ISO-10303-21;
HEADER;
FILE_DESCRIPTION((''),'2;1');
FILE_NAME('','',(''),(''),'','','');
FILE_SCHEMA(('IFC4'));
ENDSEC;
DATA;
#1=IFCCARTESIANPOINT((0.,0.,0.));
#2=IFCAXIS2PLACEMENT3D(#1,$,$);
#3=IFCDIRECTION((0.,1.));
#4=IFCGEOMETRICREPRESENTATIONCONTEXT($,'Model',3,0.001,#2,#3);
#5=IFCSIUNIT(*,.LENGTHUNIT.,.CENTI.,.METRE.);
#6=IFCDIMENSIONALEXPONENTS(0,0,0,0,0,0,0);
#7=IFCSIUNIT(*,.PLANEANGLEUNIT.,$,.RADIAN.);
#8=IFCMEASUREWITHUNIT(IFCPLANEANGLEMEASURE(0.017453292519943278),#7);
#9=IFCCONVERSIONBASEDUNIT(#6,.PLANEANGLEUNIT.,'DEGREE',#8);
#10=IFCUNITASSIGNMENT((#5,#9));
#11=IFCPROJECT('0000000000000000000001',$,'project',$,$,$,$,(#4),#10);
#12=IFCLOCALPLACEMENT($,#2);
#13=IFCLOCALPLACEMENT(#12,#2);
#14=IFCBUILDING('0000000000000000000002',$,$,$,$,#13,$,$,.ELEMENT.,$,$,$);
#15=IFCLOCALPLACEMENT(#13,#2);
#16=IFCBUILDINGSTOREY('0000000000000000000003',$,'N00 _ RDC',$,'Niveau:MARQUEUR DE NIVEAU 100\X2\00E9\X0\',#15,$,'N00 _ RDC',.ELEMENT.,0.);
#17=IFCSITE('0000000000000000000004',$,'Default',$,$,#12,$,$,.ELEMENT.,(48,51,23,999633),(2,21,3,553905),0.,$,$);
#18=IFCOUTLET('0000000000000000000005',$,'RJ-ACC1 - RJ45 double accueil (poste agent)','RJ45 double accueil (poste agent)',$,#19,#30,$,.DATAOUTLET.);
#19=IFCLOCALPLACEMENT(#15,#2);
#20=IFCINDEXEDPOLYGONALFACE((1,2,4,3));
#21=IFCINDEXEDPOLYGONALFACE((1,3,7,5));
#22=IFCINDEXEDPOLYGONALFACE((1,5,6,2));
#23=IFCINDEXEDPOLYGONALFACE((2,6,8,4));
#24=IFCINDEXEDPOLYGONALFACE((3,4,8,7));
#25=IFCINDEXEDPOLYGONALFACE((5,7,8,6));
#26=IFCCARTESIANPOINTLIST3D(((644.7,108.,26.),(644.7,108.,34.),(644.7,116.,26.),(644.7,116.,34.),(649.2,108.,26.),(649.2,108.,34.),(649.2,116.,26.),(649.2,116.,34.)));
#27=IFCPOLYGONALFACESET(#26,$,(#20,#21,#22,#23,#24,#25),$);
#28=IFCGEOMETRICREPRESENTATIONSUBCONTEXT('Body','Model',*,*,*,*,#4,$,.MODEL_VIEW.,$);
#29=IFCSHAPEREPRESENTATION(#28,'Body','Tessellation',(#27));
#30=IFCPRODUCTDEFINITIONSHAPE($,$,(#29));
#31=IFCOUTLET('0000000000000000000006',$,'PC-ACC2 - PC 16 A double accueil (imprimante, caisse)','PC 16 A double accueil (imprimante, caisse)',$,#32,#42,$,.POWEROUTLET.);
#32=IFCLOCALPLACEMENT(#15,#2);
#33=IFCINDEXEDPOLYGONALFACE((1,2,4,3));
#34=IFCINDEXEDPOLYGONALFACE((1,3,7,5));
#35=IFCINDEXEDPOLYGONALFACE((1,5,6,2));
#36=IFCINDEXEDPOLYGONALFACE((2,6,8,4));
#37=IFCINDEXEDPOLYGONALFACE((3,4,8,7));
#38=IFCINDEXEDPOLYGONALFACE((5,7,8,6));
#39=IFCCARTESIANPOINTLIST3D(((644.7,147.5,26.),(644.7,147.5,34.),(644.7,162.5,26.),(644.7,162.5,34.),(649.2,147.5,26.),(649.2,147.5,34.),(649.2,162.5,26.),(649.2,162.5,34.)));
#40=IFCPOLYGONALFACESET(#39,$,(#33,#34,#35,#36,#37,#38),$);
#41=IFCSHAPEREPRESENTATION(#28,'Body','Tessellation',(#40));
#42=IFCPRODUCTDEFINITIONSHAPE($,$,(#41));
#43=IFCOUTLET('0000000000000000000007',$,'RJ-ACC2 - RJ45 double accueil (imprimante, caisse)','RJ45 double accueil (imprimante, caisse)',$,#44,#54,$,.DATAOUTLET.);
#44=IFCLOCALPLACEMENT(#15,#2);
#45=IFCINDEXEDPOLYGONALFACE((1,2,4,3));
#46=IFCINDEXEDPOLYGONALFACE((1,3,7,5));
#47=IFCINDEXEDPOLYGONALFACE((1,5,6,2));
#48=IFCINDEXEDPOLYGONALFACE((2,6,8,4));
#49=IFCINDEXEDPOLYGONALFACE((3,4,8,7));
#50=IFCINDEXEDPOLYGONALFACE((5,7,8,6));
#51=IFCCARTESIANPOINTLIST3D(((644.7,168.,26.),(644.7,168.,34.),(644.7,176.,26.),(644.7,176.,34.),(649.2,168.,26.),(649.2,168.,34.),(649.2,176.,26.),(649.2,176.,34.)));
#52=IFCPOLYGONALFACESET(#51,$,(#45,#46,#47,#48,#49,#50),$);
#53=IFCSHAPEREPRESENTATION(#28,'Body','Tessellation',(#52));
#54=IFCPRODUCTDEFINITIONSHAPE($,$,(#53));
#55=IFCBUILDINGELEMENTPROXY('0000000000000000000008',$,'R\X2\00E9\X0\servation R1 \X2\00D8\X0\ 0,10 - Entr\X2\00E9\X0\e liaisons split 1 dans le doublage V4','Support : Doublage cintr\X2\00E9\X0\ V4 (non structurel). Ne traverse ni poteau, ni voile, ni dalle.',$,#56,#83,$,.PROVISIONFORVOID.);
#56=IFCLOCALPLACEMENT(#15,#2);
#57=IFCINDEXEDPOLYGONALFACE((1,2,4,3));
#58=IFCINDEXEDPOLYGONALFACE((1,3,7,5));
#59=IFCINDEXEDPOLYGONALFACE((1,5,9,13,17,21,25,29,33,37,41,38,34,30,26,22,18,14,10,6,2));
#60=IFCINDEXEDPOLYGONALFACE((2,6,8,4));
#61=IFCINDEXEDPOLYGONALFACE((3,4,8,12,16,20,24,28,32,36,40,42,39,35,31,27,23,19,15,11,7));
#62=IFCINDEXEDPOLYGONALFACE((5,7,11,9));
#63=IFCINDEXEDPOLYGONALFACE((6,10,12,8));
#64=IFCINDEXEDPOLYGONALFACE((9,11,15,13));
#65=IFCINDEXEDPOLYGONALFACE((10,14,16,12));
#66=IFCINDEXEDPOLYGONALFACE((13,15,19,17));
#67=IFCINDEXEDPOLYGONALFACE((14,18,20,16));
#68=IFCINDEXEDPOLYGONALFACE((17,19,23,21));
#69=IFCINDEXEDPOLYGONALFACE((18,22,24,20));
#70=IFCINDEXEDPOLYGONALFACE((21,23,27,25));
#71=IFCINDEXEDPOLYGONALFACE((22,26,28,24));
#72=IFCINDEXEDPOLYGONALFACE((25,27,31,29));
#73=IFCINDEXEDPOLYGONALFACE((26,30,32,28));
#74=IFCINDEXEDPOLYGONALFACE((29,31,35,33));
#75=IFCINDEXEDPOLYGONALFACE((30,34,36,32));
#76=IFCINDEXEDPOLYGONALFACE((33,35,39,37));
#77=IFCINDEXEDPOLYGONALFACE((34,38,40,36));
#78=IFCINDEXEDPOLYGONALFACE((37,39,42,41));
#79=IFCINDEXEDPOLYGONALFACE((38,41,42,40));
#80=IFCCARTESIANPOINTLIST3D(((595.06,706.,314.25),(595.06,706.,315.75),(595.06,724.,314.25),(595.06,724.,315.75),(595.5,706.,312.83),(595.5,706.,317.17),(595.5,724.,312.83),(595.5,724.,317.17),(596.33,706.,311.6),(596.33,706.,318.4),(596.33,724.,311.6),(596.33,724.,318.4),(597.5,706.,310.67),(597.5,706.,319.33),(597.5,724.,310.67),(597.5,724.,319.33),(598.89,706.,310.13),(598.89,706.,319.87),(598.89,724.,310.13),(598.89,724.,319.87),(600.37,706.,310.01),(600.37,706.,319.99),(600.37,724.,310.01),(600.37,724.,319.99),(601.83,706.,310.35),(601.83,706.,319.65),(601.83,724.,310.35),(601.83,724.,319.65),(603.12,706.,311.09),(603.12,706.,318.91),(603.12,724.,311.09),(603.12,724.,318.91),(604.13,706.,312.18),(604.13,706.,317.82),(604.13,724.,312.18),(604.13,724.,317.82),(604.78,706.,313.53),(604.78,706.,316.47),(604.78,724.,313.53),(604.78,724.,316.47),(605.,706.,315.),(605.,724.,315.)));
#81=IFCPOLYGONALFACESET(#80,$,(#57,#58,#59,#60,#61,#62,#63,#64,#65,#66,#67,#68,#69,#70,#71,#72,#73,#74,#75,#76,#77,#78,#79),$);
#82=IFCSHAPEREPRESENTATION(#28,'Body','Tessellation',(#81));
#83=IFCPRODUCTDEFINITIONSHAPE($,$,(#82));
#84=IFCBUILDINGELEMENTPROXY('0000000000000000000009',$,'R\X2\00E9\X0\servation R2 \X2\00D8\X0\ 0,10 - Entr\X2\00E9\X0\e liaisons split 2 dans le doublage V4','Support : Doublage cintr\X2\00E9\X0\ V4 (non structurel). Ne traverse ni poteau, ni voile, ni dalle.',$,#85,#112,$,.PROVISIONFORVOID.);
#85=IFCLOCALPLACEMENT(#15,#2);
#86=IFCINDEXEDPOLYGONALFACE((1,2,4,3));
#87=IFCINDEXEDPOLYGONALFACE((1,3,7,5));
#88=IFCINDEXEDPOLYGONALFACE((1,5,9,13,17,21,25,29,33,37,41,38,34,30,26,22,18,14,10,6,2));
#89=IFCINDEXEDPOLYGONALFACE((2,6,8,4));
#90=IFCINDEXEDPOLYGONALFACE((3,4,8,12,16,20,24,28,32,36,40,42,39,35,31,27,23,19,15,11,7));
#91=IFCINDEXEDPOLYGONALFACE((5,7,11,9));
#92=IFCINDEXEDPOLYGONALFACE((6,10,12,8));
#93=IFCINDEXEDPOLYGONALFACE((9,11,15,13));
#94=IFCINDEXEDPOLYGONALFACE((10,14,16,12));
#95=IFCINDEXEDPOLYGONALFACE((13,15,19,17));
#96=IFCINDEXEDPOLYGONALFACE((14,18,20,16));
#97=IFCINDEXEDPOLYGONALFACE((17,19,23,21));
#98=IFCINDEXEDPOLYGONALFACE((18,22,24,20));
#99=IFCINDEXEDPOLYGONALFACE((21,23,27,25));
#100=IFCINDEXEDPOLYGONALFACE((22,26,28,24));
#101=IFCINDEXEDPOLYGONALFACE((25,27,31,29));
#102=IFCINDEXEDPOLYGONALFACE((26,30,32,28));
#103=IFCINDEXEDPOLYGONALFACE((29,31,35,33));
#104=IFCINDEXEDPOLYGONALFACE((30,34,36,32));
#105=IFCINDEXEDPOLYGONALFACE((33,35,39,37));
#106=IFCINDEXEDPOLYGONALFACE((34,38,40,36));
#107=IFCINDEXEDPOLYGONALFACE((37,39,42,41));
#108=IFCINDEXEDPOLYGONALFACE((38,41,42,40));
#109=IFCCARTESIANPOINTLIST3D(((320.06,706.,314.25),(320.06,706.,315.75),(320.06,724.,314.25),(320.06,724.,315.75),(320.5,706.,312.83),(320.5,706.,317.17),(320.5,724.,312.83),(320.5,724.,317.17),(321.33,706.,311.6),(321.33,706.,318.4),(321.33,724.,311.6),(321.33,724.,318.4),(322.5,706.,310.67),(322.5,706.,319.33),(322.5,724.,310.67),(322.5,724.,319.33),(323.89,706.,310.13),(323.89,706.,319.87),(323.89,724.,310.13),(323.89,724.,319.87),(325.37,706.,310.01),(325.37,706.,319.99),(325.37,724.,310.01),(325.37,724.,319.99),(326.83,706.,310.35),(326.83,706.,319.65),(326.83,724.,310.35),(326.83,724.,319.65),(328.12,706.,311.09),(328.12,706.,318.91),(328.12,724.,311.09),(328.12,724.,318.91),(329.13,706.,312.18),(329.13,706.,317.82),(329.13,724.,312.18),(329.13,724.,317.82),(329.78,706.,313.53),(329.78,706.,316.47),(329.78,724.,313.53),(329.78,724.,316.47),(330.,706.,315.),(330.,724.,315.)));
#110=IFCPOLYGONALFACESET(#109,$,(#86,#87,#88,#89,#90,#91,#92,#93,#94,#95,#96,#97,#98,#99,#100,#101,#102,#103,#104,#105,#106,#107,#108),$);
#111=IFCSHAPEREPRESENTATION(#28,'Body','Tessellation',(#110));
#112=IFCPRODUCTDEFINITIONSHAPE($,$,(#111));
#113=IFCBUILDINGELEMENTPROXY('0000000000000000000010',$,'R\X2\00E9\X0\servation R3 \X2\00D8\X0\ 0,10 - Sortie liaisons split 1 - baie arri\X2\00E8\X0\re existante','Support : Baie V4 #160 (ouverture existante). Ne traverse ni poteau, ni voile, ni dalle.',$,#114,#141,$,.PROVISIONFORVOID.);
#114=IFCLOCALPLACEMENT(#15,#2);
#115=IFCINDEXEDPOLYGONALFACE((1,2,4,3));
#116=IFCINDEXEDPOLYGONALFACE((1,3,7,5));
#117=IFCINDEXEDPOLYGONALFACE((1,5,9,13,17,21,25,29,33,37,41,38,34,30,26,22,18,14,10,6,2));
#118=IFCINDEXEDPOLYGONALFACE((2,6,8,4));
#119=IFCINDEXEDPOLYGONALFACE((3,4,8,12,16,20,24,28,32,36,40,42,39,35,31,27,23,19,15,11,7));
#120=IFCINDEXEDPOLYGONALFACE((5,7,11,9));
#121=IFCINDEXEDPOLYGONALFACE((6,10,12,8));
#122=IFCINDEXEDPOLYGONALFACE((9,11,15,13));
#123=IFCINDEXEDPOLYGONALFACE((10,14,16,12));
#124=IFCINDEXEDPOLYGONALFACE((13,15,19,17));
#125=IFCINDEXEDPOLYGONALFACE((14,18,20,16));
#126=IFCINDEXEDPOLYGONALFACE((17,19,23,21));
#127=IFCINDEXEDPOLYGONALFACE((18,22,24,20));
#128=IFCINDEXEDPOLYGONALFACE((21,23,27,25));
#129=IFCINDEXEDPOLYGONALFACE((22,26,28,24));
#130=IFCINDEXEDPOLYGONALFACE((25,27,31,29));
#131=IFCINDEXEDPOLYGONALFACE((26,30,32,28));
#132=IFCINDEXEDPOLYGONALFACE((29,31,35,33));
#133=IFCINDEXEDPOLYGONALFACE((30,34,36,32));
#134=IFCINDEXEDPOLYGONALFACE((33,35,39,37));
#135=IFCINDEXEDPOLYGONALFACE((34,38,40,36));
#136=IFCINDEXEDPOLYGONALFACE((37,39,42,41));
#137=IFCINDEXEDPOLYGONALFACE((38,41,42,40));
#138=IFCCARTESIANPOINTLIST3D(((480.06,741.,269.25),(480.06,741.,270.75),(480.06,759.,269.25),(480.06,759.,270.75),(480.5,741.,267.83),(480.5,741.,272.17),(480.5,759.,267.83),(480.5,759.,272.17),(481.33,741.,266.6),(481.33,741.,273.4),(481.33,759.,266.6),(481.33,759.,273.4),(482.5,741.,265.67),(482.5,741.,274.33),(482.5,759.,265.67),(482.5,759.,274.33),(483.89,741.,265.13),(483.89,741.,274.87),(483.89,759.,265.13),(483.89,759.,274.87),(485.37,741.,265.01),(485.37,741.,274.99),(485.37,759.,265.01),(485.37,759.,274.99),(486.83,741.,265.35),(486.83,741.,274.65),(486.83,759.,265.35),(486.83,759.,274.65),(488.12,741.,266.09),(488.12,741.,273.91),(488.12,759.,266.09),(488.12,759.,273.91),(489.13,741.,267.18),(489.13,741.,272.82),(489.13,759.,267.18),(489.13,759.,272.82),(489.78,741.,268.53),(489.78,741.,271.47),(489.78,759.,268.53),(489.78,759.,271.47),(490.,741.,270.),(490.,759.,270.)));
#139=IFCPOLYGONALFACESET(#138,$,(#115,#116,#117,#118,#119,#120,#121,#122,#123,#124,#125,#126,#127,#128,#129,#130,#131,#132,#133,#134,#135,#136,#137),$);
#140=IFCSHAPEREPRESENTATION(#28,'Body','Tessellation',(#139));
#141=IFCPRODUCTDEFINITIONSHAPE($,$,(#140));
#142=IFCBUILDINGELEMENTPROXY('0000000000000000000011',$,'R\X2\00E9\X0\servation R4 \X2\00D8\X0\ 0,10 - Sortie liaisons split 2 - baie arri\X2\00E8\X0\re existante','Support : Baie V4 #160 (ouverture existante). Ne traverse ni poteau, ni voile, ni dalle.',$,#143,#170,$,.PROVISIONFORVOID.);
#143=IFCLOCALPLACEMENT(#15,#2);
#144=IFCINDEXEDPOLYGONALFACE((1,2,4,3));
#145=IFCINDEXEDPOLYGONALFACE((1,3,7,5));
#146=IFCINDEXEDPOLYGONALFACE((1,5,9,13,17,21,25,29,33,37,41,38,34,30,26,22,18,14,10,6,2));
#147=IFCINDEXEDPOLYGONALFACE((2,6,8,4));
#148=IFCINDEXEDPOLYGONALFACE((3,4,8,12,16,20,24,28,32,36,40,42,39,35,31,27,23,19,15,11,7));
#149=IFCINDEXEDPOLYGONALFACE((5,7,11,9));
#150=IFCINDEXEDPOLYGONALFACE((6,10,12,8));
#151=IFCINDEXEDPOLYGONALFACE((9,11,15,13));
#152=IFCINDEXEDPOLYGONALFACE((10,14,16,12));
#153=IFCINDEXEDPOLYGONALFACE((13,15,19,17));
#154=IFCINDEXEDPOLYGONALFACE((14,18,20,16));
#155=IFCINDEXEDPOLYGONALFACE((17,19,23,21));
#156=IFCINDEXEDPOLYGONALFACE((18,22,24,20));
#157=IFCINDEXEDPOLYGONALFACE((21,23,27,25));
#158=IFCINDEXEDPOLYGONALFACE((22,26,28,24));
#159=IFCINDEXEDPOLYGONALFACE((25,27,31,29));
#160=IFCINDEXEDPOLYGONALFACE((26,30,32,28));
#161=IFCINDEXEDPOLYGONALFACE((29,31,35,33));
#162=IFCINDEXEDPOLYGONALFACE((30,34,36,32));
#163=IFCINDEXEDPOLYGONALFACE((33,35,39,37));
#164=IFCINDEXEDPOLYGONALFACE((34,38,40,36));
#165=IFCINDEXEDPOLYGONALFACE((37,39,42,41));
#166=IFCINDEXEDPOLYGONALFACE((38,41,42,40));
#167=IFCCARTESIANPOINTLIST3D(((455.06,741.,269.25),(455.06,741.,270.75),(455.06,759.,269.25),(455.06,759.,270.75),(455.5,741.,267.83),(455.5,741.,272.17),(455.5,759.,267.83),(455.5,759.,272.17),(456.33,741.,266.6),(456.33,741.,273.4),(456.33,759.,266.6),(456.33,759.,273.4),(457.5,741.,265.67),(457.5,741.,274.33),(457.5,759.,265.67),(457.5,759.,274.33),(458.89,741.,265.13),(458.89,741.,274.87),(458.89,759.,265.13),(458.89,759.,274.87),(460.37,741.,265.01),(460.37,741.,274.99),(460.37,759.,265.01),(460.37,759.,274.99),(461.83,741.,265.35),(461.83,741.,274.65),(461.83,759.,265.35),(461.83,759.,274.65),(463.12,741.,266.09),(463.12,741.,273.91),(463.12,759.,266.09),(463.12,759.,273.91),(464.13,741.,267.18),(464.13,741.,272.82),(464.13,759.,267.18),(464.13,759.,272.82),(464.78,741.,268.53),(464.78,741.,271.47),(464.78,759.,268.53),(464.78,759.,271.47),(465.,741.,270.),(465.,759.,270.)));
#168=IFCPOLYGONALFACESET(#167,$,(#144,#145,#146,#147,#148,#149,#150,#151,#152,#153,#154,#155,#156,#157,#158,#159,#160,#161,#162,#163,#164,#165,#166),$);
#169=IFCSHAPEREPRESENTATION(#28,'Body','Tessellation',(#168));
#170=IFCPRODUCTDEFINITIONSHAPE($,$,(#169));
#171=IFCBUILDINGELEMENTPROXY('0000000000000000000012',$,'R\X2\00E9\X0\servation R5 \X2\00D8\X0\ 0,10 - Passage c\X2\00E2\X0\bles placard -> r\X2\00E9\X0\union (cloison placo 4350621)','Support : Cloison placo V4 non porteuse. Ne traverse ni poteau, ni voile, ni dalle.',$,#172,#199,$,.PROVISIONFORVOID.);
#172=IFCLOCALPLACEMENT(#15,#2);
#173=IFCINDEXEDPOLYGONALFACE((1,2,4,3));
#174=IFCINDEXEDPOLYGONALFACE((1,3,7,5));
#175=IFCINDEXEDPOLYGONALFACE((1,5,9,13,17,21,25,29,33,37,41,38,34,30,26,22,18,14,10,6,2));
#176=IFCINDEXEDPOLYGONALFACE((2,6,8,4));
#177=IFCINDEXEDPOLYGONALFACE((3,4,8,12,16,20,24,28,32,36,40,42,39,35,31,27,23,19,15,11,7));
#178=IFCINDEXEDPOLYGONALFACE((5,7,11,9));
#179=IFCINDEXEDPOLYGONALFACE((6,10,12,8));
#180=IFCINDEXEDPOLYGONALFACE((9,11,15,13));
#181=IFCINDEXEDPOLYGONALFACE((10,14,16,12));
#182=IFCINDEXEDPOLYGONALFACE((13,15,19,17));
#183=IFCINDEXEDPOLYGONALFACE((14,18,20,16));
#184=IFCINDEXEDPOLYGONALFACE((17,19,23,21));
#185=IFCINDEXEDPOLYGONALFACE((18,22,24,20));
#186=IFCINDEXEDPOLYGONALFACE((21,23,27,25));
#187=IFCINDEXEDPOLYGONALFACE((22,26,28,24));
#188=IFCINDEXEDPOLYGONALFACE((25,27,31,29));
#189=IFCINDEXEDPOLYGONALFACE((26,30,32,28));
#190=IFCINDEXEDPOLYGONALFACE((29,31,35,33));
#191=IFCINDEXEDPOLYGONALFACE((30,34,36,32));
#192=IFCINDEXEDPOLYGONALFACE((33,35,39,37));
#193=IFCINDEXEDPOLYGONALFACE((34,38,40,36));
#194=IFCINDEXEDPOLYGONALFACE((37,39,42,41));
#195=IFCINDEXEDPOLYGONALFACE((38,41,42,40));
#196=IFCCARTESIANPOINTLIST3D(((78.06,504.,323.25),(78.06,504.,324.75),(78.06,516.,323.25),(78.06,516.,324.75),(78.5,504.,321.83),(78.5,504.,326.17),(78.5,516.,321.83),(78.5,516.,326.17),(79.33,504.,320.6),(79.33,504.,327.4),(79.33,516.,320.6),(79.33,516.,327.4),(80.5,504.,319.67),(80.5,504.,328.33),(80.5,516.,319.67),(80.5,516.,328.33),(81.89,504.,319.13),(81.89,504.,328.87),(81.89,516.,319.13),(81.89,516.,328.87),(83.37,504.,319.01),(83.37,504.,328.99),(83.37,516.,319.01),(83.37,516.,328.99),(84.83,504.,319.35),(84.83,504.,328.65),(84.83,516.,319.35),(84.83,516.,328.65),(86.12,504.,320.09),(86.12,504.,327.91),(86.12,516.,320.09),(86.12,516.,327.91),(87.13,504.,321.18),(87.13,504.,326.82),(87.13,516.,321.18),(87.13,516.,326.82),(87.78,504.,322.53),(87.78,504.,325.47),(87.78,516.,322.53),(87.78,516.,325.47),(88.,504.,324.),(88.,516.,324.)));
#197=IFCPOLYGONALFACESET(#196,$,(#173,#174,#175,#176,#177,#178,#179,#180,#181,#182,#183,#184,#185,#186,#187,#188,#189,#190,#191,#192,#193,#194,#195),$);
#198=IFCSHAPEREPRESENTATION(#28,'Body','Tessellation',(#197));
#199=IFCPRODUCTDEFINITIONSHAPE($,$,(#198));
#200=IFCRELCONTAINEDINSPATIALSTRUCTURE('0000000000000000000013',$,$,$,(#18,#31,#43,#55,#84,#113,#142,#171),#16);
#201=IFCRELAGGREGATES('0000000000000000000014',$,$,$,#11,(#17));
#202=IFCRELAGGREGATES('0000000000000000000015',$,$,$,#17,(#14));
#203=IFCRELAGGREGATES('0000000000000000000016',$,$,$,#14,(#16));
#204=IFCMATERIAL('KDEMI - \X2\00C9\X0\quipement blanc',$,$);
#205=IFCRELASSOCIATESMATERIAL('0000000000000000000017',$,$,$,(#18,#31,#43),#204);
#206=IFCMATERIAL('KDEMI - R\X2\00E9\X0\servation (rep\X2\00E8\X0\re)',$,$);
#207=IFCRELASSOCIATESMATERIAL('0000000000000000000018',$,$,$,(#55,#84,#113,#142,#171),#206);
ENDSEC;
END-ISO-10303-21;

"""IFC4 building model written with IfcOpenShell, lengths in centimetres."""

from ifc_helpers import new_model, entity, si_unit, converted_unit, direction, frame, frame_2d, origin, origin_with_axes, origin_2d, place, context, subcontext, project, spatial, rectangle, circle, extrude, material, element, save


model = new_model("IFC4")

# Units and contexts
model_context = context("Model", 3, precision=0.001, world=origin(), true_north=direction((0.0, 1.0)))
body_context = subcontext(model_context, "Body", "Model", "MODEL_VIEW")
ifc_project = project(units=[si_unit("LENGTHUNIT", "METRE", prefix="CENTI"), converted_unit("PLANEANGLEUNIT", "DEGREE", entity("IfcPlaneAngleMeasure", 0.017453292519943278), si_unit("PLANEANGLEUNIT", "RADIAN"), dimensions=[0, 0, 0, 0, 0, 0, 0])], contexts=[model_context])

# Site, building, storey
site_placement = place(None, origin())
site = spatial("IfcSite", under=ifc_project, at=site_placement, Name="Default", CompositionType="ELEMENT", RefLatitude=(48, 51, 23, 999633), RefLongitude=(2, 21, 3, 553905), RefElevation=0.0)
building_placement = place(site_placement, origin())
building = spatial("IfcBuilding", under=site, at=building_placement, CompositionType="ELEMENT")
storey_placement = place(building_placement, origin())
storey = spatial("IfcBuildingStorey", under=building, at=storey_placement, Name="N00 _ RDC", ObjectType="Niveau:MARQUEUR DE NIVEAU 100é", LongName="N00 _ RDC", CompositionType="ELEMENT", Elevation=0.0)

# Shared definitions
ifc_material_1 = material(Name="KDEMI - Équipement blanc")

# Outlets
outlet_1_placement = place(storey_placement, origin_with_axes())
element("IfcOutlet", 1, at=outlet_1_placement, inside=storey, material=ifc_material_1, Name="RJ-ACC1 - RJ45 double accueil (poste agent)", Description="RJ45 double accueil (poste agent)", PredefinedType="DATAOUTLET", context=body_context, shape_type="SweptSolid", body=[
    extrude(rectangle(XDim=4.5, YDim=8.0, at=frame_2d((646.95, 112.0))), frame((0.0, 0.0, 26.0)), (0.0, 0.0, 1.0), 8.0),
])
outlet_2_placement = place(storey_placement, origin_with_axes())
element("IfcOutlet", 2, at=outlet_2_placement, inside=storey, material=ifc_material_1, Name="PC-ACC2 - PC 16 A double accueil (imprimante, caisse)", Description="PC 16 A double accueil (imprimante, caisse)", PredefinedType="POWEROUTLET", context=body_context, shape_type="SweptSolid", body=[
    extrude(rectangle(XDim=4.5, YDim=15.0, at=frame_2d((646.95, 155.0))), frame((0.0, 0.0, 26.0)), (0.0, 0.0, 1.0), 8.0),
])
outlet_3_placement = place(storey_placement, origin_with_axes())
element("IfcOutlet", 3, at=outlet_3_placement, inside=storey, material=ifc_material_1, Name="RJ-ACC2 - RJ45 double accueil (imprimante, caisse)", Description="RJ45 double accueil (imprimante, caisse)", PredefinedType="DATAOUTLET", context=body_context, shape_type="SweptSolid", body=[
    extrude(rectangle(XDim=4.5, YDim=8.0, at=frame_2d((646.95, 172.0))), frame((0.0, 0.0, 26.0)), (0.0, 0.0, 1.0), 8.0),
])

# Building element proxies
ifc_material_2 = material(Name="KDEMI - Réservation (repère)")
proxy_1_placement = place(storey_placement, origin_with_axes())
element("IfcBuildingElementProxy", 4, at=proxy_1_placement, inside=storey, material=ifc_material_2, Name="Réservation R1 Ø 0,10 - Entrée liaisons split 1 dans le doublage V4", Description="Support : Doublage cintré V4 (non structurel). Ne traverse ni poteau, ni voile, ni dalle.", PredefinedType="PROVISIONFORVOID", context=body_context, shape_type="SweptSolid", body=[
    extrude(circle(Radius=5.0, at=origin_2d()), frame((600.0, 706.0, 315.0), z_axis=(0.0, 1.0, 0.0), x_axis=(1.0, 0.0, 0.0)), (0.0, 0.0, 1.0), 18.0),
])
proxy_2_placement = place(storey_placement, origin_with_axes())
element("IfcBuildingElementProxy", 5, at=proxy_2_placement, inside=storey, material=ifc_material_2, Name="Réservation R2 Ø 0,10 - Entrée liaisons split 2 dans le doublage V4", Description="Support : Doublage cintré V4 (non structurel). Ne traverse ni poteau, ni voile, ni dalle.", PredefinedType="PROVISIONFORVOID", context=body_context, shape_type="SweptSolid", body=[
    extrude(circle(Radius=5.0, at=origin_2d()), frame((325.0, 706.0, 315.0), z_axis=(0.0, 1.0, 0.0), x_axis=(1.0, 0.0, 0.0)), (0.0, 0.0, 1.0), 18.0),
])
proxy_3_placement = place(storey_placement, origin_with_axes())
element("IfcBuildingElementProxy", 6, at=proxy_3_placement, inside=storey, material=ifc_material_2, Name="Réservation R3 Ø 0,10 - Sortie liaisons split 1 - baie arrière existante", Description="Support : Baie V4 #160 (ouverture existante). Ne traverse ni poteau, ni voile, ni dalle.", PredefinedType="PROVISIONFORVOID", context=body_context, shape_type="SweptSolid", body=[
    extrude(circle(Radius=5.0, at=origin_2d()), frame((485.0, 741.0, 270.0), z_axis=(0.0, 1.0, 0.0), x_axis=(1.0, 0.0, 0.0)), (0.0, 0.0, 1.0), 18.0),
])
proxy_4_placement = place(storey_placement, origin_with_axes())
element("IfcBuildingElementProxy", 7, at=proxy_4_placement, inside=storey, material=ifc_material_2, Name="Réservation R4 Ø 0,10 - Sortie liaisons split 2 - baie arrière existante", Description="Support : Baie V4 #160 (ouverture existante). Ne traverse ni poteau, ni voile, ni dalle.", PredefinedType="PROVISIONFORVOID", context=body_context, shape_type="SweptSolid", body=[
    extrude(circle(Radius=5.0, at=origin_2d()), frame((460.0, 741.0, 270.0), z_axis=(0.0, 1.0, 0.0), x_axis=(1.0, 0.0, 0.0)), (0.0, 0.0, 1.0), 18.0),
])
proxy_5_placement = place(storey_placement, origin_with_axes())
element("IfcBuildingElementProxy", 8, at=proxy_5_placement, inside=storey, material=ifc_material_2, Name="Réservation R5 Ø 0,10 - Passage câbles placard -> réunion (cloison placo 4350621)", Description="Support : Cloison placo V4 non porteuse. Ne traverse ni poteau, ni voile, ni dalle.", PredefinedType="PROVISIONFORVOID", context=body_context, shape_type="SweptSolid", body=[
    extrude(circle(Radius=5.0, at=origin_2d()), frame((83.0, 504.0, 324.0), z_axis=(0.0, 1.0, 0.0), x_axis=(1.0, 0.0, 0.0)), (0.0, 0.0, 1.0), 12.0),
])

save(model, "model.ifc")
